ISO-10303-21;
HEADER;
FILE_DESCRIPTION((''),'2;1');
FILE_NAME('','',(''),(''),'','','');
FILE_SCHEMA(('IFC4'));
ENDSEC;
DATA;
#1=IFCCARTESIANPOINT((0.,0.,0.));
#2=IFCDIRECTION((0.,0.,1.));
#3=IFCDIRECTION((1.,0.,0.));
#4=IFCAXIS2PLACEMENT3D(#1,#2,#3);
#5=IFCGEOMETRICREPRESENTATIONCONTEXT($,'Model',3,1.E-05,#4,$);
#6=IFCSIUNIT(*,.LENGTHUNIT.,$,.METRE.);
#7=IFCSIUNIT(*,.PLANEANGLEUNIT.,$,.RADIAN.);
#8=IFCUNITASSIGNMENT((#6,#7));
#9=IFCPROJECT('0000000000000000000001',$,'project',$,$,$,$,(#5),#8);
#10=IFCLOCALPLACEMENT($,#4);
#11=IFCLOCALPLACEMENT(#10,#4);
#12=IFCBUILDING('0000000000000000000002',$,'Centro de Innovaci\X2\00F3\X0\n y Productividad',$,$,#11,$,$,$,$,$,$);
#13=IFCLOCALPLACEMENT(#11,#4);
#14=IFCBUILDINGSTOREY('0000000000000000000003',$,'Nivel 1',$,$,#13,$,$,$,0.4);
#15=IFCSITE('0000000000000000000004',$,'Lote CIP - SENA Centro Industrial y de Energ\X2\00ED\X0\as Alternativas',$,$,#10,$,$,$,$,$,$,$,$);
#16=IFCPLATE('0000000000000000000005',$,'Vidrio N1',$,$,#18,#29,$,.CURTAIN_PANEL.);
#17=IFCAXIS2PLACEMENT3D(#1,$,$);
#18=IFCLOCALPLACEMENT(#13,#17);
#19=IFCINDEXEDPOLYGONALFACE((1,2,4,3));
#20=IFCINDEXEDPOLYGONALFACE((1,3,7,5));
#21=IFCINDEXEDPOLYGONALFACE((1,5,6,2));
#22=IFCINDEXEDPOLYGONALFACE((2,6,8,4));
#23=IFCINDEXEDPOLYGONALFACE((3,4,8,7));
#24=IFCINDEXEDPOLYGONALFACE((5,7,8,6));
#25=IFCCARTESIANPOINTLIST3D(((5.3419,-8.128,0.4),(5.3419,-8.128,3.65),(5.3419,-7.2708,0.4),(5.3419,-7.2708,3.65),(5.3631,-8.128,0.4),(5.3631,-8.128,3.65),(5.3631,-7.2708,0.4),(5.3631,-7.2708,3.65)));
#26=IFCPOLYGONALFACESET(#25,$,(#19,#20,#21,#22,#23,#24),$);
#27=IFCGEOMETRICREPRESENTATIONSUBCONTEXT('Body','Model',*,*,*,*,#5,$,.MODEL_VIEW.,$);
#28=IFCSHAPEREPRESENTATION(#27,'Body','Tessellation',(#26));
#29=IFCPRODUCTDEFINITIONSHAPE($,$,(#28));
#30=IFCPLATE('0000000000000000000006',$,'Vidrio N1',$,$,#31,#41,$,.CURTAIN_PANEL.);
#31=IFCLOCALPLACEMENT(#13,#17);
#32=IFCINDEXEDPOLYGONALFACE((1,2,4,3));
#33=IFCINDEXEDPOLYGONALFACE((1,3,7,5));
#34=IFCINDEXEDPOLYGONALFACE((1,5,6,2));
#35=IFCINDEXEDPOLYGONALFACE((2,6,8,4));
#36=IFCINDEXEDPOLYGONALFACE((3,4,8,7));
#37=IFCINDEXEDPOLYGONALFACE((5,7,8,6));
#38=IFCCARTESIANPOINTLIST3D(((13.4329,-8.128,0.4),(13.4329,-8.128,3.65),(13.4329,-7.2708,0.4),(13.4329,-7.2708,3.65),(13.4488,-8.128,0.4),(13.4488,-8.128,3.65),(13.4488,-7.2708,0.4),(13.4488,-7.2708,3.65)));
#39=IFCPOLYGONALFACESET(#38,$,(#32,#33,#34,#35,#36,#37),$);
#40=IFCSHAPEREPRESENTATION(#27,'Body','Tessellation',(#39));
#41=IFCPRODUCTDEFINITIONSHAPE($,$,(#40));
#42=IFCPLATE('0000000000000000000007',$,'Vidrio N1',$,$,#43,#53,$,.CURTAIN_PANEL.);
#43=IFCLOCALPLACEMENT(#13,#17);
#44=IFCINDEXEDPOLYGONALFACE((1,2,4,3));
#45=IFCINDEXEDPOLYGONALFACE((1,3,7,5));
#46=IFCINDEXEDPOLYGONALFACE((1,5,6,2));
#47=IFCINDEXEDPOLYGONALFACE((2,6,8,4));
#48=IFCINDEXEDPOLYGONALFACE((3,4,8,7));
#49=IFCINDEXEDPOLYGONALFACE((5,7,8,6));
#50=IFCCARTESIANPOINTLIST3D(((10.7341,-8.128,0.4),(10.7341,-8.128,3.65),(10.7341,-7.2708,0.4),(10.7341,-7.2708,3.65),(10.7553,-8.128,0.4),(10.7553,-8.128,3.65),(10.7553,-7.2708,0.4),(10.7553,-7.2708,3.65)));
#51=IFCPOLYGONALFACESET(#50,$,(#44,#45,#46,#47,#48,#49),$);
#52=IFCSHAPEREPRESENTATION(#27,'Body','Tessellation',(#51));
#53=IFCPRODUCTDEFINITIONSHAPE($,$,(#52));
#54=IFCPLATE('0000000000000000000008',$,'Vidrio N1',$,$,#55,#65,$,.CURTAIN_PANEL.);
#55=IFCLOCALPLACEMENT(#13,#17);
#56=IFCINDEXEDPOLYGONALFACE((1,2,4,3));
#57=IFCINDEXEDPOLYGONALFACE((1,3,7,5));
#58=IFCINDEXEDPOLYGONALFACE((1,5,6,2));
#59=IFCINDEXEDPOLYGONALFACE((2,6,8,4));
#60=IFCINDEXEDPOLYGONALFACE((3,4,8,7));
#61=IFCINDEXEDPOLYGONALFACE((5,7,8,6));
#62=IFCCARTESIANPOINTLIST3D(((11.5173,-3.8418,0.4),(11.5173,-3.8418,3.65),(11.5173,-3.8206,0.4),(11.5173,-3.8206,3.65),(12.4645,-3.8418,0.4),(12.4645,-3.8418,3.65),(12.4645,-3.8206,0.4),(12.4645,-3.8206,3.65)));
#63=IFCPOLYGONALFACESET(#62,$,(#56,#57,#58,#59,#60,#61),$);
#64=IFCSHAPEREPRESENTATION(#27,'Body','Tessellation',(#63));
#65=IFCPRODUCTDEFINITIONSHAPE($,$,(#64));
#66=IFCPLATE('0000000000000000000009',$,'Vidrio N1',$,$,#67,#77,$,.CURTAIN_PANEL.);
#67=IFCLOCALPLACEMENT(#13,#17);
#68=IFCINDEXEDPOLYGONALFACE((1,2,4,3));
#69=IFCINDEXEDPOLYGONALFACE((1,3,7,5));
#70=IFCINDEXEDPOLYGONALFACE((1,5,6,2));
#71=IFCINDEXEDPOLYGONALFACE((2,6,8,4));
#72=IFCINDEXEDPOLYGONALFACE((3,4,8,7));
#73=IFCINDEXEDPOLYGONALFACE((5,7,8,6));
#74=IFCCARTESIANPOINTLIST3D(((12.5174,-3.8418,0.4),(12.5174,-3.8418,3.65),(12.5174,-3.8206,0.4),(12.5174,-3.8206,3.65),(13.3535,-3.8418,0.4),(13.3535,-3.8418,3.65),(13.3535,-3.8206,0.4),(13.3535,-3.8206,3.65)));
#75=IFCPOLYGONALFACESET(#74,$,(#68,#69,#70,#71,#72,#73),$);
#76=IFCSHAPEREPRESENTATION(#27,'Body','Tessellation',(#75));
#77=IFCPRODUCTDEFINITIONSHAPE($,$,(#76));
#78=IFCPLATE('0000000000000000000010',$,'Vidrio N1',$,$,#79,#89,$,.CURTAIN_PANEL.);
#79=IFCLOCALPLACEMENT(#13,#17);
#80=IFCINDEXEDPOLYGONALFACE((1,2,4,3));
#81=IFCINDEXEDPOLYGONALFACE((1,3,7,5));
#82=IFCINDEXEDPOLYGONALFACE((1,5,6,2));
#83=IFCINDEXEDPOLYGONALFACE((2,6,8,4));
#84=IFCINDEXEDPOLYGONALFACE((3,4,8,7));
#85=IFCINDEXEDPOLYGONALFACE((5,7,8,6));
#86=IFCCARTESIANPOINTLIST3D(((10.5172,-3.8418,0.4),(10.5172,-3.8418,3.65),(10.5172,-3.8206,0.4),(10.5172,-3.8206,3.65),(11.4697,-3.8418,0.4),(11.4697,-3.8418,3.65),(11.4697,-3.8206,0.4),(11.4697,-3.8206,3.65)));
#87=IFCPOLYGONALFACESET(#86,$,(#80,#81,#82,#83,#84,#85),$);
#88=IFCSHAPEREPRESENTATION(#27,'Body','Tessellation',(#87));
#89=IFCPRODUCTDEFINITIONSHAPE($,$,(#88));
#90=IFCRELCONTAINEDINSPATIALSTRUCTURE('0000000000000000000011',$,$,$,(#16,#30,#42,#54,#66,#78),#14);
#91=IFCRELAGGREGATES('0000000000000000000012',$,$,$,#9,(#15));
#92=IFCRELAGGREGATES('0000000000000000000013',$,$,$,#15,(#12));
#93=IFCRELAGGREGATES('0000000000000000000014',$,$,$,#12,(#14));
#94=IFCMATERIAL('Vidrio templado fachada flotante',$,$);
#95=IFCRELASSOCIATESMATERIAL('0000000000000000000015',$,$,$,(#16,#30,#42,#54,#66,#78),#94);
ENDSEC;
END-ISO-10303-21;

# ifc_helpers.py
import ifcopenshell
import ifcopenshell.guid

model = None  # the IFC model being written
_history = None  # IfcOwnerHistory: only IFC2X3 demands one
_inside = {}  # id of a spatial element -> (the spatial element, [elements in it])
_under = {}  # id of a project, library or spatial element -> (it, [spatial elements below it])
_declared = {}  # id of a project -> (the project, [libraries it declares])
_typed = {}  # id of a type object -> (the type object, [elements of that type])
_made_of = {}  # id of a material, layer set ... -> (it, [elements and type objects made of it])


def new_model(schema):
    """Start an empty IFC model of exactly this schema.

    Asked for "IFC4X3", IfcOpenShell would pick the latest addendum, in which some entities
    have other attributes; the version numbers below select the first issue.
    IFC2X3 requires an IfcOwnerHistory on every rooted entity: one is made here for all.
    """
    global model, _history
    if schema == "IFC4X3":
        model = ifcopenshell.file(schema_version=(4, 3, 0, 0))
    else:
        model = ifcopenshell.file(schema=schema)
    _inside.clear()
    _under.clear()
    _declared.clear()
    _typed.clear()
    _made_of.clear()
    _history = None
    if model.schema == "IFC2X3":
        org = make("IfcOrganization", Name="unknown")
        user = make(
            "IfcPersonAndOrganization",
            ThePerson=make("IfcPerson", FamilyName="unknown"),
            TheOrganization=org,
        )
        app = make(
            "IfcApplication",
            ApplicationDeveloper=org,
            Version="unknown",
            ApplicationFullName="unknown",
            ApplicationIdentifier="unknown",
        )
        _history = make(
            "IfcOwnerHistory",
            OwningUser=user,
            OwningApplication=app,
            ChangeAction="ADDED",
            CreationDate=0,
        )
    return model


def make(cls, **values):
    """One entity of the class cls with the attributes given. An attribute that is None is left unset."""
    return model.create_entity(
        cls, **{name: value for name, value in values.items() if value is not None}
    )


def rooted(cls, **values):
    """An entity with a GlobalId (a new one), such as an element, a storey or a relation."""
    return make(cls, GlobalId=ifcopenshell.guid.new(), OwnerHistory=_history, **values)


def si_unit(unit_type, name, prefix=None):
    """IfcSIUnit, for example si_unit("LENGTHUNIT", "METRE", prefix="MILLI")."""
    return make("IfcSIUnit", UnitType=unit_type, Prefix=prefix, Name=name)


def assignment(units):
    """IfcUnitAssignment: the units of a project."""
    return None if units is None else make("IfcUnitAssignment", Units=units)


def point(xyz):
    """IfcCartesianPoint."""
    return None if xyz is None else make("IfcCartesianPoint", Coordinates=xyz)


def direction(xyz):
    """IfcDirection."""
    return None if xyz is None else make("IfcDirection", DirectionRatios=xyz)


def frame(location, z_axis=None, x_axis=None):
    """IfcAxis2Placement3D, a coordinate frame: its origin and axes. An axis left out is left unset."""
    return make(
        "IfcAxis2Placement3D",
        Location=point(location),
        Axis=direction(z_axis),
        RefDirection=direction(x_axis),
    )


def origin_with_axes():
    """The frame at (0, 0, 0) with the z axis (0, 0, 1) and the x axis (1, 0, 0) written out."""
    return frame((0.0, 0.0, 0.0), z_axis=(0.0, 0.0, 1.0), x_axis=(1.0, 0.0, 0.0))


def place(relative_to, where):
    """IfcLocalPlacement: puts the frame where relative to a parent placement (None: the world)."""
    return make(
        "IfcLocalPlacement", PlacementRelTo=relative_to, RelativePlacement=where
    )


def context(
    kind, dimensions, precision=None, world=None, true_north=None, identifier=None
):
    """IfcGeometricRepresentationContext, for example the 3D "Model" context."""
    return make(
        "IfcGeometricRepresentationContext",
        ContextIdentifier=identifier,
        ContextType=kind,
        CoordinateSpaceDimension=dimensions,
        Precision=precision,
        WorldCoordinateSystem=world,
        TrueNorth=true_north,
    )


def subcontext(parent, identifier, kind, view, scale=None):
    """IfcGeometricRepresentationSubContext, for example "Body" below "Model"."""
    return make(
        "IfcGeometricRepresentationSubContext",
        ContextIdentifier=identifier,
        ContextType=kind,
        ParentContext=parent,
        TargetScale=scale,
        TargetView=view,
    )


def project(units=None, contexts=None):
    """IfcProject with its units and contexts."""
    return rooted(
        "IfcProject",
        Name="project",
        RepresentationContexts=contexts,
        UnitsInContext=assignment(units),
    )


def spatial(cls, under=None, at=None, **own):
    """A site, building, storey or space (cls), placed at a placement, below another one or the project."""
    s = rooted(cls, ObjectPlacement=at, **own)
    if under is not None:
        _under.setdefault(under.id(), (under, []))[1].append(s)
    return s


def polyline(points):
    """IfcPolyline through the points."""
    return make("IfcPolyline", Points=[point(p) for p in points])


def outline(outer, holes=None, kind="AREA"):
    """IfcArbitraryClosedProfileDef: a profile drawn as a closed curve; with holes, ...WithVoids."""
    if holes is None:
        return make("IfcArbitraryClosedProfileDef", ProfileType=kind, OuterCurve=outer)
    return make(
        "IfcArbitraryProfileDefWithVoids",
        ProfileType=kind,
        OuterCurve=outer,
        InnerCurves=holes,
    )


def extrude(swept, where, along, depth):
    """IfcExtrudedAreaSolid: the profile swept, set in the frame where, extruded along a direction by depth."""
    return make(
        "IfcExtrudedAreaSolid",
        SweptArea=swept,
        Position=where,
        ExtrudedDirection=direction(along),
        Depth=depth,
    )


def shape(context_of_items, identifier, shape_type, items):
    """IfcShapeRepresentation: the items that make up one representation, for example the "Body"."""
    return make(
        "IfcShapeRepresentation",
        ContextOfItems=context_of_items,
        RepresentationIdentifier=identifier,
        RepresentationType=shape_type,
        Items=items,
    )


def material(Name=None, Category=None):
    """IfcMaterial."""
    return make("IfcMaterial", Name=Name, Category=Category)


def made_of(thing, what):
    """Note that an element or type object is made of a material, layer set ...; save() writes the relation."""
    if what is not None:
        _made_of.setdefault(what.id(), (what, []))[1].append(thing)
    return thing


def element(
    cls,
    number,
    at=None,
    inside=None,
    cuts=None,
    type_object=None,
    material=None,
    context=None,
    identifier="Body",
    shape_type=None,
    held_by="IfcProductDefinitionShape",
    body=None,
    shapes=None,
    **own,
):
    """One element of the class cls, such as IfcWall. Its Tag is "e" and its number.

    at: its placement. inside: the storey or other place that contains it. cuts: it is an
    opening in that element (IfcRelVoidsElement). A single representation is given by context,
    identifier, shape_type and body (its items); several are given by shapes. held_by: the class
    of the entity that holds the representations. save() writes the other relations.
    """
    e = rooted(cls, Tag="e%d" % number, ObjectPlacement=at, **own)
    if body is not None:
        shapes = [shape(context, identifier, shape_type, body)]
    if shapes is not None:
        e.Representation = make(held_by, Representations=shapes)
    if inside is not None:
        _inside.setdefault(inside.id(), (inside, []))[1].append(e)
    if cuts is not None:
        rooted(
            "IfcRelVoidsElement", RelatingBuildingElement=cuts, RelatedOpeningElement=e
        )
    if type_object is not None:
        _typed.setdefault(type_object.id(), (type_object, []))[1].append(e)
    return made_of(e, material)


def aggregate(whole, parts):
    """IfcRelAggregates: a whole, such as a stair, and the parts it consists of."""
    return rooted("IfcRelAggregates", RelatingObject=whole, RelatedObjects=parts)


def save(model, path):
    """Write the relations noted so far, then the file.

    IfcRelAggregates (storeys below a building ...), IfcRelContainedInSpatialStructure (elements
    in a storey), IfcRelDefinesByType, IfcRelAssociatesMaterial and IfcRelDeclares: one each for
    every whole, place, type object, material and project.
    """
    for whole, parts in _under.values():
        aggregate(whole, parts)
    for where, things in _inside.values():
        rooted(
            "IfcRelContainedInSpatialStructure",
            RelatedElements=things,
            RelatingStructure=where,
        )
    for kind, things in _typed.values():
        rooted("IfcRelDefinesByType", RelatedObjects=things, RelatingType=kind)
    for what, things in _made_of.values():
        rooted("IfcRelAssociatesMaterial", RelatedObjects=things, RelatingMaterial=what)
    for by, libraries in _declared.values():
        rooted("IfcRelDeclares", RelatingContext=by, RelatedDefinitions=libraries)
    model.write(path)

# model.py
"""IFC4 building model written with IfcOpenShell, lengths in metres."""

from ifc_helpers import new_model, si_unit, frame, origin_with_axes, place, context, subcontext, project, spatial, polyline, outline, extrude, material, element, save


model = new_model("IFC4")

# Units and contexts
model_context = context("Model", 3, precision=1e-05, world=origin_with_axes())
body_context = subcontext(model_context, "Body", "Model", "MODEL_VIEW")
ifc_project = project(units=[si_unit("LENGTHUNIT", "METRE"), si_unit("PLANEANGLEUNIT", "RADIAN")], contexts=[model_context])

# Site, building, storey
site_placement = place(None, origin_with_axes())
site = spatial("IfcSite", under=ifc_project, at=site_placement, Name="Lote CIP - SENA Centro Industrial y de Energías Alternativas")
building_placement = place(site_placement, origin_with_axes())
building = spatial("IfcBuilding", under=site, at=building_placement, Name="Centro de Innovación y Productividad")
storey_placement = place(building_placement, origin_with_axes())
storey = spatial("IfcBuildingStorey", under=building, at=storey_placement, Name="Nivel 1", Elevation=0.4)

# Plates
ifc_material = material(Name="Vidrio templado fachada flotante")
plate_1_placement = place(storey_placement, origin_with_axes())
element("IfcPlate", 1, at=plate_1_placement, inside=storey, material=ifc_material, Name="Vidrio N1", PredefinedType="CURTAIN_PANEL", context=body_context, shape_type="SweptSolid", body=[
    extrude(outline(polyline([(5.3631, -7.2708), (5.3631, -8.128), (5.3419, -8.128), (5.3419, -7.2708), (5.3631, -7.2708)])), frame((0.0, 0.0, 0.4)), (0.0, 0.0, 1.0), 3.25),
])
plate_2_placement = place(storey_placement, origin_with_axes())
element("IfcPlate", 2, at=plate_2_placement, inside=storey, material=ifc_material, Name="Vidrio N1", PredefinedType="CURTAIN_PANEL", context=body_context, shape_type="SweptSolid", body=[
    extrude(outline(polyline([(13.4488, -7.2708), (13.4488, -8.128), (13.4329, -8.128), (13.4329, -7.2708), (13.4488, -7.2708)])), frame((0.0, 0.0, 0.4)), (0.0, 0.0, 1.0), 3.25),
])
plate_3_placement = place(storey_placement, origin_with_axes())
element("IfcPlate", 3, at=plate_3_placement, inside=storey, material=ifc_material, Name="Vidrio N1", PredefinedType="CURTAIN_PANEL", context=body_context, shape_type="SweptSolid", body=[
    extrude(outline(polyline([(10.7553, -8.128), (10.7341, -8.128), (10.7341, -7.2708), (10.7553, -7.2708), (10.7553, -8.128)])), frame((0.0, 0.0, 0.4)), (0.0, 0.0, 1.0), 3.25),
])
plate_4_placement = place(storey_placement, origin_with_axes())
element("IfcPlate", 4, at=plate_4_placement, inside=storey, material=ifc_material, Name="Vidrio N1", PredefinedType="CURTAIN_PANEL", context=body_context, shape_type="SweptSolid", body=[
    extrude(outline(polyline([(12.4645, -3.8206), (12.4645, -3.8417), (11.5173, -3.8417), (11.5173, -3.8206), (12.4645, -3.8206)])), frame((0.0, 0.0, 0.4)), (0.0, 0.0, 1.0), 3.25),
])
plate_5_placement = place(storey_placement, origin_with_axes())
element("IfcPlate", 5, at=plate_5_placement, inside=storey, material=ifc_material, Name="Vidrio N1", PredefinedType="CURTAIN_PANEL", context=body_context, shape_type="SweptSolid", body=[
    extrude(outline(polyline([(12.5174, -3.8417), (12.5174, -3.8206), (13.3535, -3.8206), (13.3535, -3.8417), (12.5174, -3.8417)])), frame((0.0, 0.0, 0.4)), (0.0, 0.0, 1.0), 3.25),
])
plate_6_placement = place(storey_placement, origin_with_axes())
element("IfcPlate", 6, at=plate_6_placement, inside=storey, material=ifc_material, Name="Vidrio N1", PredefinedType="CURTAIN_PANEL", context=body_context, shape_type="SweptSolid", body=[
    extrude(outline(polyline([(11.4697, -3.8417), (10.5172, -3.8417), (10.5172, -3.8206), (11.4697, -3.8206), (11.4697, -3.8417)])), frame((0.0, 0.0, 0.4)), (0.0, 0.0, 1.0), 3.25),
])

save(model, "model.ifc")
